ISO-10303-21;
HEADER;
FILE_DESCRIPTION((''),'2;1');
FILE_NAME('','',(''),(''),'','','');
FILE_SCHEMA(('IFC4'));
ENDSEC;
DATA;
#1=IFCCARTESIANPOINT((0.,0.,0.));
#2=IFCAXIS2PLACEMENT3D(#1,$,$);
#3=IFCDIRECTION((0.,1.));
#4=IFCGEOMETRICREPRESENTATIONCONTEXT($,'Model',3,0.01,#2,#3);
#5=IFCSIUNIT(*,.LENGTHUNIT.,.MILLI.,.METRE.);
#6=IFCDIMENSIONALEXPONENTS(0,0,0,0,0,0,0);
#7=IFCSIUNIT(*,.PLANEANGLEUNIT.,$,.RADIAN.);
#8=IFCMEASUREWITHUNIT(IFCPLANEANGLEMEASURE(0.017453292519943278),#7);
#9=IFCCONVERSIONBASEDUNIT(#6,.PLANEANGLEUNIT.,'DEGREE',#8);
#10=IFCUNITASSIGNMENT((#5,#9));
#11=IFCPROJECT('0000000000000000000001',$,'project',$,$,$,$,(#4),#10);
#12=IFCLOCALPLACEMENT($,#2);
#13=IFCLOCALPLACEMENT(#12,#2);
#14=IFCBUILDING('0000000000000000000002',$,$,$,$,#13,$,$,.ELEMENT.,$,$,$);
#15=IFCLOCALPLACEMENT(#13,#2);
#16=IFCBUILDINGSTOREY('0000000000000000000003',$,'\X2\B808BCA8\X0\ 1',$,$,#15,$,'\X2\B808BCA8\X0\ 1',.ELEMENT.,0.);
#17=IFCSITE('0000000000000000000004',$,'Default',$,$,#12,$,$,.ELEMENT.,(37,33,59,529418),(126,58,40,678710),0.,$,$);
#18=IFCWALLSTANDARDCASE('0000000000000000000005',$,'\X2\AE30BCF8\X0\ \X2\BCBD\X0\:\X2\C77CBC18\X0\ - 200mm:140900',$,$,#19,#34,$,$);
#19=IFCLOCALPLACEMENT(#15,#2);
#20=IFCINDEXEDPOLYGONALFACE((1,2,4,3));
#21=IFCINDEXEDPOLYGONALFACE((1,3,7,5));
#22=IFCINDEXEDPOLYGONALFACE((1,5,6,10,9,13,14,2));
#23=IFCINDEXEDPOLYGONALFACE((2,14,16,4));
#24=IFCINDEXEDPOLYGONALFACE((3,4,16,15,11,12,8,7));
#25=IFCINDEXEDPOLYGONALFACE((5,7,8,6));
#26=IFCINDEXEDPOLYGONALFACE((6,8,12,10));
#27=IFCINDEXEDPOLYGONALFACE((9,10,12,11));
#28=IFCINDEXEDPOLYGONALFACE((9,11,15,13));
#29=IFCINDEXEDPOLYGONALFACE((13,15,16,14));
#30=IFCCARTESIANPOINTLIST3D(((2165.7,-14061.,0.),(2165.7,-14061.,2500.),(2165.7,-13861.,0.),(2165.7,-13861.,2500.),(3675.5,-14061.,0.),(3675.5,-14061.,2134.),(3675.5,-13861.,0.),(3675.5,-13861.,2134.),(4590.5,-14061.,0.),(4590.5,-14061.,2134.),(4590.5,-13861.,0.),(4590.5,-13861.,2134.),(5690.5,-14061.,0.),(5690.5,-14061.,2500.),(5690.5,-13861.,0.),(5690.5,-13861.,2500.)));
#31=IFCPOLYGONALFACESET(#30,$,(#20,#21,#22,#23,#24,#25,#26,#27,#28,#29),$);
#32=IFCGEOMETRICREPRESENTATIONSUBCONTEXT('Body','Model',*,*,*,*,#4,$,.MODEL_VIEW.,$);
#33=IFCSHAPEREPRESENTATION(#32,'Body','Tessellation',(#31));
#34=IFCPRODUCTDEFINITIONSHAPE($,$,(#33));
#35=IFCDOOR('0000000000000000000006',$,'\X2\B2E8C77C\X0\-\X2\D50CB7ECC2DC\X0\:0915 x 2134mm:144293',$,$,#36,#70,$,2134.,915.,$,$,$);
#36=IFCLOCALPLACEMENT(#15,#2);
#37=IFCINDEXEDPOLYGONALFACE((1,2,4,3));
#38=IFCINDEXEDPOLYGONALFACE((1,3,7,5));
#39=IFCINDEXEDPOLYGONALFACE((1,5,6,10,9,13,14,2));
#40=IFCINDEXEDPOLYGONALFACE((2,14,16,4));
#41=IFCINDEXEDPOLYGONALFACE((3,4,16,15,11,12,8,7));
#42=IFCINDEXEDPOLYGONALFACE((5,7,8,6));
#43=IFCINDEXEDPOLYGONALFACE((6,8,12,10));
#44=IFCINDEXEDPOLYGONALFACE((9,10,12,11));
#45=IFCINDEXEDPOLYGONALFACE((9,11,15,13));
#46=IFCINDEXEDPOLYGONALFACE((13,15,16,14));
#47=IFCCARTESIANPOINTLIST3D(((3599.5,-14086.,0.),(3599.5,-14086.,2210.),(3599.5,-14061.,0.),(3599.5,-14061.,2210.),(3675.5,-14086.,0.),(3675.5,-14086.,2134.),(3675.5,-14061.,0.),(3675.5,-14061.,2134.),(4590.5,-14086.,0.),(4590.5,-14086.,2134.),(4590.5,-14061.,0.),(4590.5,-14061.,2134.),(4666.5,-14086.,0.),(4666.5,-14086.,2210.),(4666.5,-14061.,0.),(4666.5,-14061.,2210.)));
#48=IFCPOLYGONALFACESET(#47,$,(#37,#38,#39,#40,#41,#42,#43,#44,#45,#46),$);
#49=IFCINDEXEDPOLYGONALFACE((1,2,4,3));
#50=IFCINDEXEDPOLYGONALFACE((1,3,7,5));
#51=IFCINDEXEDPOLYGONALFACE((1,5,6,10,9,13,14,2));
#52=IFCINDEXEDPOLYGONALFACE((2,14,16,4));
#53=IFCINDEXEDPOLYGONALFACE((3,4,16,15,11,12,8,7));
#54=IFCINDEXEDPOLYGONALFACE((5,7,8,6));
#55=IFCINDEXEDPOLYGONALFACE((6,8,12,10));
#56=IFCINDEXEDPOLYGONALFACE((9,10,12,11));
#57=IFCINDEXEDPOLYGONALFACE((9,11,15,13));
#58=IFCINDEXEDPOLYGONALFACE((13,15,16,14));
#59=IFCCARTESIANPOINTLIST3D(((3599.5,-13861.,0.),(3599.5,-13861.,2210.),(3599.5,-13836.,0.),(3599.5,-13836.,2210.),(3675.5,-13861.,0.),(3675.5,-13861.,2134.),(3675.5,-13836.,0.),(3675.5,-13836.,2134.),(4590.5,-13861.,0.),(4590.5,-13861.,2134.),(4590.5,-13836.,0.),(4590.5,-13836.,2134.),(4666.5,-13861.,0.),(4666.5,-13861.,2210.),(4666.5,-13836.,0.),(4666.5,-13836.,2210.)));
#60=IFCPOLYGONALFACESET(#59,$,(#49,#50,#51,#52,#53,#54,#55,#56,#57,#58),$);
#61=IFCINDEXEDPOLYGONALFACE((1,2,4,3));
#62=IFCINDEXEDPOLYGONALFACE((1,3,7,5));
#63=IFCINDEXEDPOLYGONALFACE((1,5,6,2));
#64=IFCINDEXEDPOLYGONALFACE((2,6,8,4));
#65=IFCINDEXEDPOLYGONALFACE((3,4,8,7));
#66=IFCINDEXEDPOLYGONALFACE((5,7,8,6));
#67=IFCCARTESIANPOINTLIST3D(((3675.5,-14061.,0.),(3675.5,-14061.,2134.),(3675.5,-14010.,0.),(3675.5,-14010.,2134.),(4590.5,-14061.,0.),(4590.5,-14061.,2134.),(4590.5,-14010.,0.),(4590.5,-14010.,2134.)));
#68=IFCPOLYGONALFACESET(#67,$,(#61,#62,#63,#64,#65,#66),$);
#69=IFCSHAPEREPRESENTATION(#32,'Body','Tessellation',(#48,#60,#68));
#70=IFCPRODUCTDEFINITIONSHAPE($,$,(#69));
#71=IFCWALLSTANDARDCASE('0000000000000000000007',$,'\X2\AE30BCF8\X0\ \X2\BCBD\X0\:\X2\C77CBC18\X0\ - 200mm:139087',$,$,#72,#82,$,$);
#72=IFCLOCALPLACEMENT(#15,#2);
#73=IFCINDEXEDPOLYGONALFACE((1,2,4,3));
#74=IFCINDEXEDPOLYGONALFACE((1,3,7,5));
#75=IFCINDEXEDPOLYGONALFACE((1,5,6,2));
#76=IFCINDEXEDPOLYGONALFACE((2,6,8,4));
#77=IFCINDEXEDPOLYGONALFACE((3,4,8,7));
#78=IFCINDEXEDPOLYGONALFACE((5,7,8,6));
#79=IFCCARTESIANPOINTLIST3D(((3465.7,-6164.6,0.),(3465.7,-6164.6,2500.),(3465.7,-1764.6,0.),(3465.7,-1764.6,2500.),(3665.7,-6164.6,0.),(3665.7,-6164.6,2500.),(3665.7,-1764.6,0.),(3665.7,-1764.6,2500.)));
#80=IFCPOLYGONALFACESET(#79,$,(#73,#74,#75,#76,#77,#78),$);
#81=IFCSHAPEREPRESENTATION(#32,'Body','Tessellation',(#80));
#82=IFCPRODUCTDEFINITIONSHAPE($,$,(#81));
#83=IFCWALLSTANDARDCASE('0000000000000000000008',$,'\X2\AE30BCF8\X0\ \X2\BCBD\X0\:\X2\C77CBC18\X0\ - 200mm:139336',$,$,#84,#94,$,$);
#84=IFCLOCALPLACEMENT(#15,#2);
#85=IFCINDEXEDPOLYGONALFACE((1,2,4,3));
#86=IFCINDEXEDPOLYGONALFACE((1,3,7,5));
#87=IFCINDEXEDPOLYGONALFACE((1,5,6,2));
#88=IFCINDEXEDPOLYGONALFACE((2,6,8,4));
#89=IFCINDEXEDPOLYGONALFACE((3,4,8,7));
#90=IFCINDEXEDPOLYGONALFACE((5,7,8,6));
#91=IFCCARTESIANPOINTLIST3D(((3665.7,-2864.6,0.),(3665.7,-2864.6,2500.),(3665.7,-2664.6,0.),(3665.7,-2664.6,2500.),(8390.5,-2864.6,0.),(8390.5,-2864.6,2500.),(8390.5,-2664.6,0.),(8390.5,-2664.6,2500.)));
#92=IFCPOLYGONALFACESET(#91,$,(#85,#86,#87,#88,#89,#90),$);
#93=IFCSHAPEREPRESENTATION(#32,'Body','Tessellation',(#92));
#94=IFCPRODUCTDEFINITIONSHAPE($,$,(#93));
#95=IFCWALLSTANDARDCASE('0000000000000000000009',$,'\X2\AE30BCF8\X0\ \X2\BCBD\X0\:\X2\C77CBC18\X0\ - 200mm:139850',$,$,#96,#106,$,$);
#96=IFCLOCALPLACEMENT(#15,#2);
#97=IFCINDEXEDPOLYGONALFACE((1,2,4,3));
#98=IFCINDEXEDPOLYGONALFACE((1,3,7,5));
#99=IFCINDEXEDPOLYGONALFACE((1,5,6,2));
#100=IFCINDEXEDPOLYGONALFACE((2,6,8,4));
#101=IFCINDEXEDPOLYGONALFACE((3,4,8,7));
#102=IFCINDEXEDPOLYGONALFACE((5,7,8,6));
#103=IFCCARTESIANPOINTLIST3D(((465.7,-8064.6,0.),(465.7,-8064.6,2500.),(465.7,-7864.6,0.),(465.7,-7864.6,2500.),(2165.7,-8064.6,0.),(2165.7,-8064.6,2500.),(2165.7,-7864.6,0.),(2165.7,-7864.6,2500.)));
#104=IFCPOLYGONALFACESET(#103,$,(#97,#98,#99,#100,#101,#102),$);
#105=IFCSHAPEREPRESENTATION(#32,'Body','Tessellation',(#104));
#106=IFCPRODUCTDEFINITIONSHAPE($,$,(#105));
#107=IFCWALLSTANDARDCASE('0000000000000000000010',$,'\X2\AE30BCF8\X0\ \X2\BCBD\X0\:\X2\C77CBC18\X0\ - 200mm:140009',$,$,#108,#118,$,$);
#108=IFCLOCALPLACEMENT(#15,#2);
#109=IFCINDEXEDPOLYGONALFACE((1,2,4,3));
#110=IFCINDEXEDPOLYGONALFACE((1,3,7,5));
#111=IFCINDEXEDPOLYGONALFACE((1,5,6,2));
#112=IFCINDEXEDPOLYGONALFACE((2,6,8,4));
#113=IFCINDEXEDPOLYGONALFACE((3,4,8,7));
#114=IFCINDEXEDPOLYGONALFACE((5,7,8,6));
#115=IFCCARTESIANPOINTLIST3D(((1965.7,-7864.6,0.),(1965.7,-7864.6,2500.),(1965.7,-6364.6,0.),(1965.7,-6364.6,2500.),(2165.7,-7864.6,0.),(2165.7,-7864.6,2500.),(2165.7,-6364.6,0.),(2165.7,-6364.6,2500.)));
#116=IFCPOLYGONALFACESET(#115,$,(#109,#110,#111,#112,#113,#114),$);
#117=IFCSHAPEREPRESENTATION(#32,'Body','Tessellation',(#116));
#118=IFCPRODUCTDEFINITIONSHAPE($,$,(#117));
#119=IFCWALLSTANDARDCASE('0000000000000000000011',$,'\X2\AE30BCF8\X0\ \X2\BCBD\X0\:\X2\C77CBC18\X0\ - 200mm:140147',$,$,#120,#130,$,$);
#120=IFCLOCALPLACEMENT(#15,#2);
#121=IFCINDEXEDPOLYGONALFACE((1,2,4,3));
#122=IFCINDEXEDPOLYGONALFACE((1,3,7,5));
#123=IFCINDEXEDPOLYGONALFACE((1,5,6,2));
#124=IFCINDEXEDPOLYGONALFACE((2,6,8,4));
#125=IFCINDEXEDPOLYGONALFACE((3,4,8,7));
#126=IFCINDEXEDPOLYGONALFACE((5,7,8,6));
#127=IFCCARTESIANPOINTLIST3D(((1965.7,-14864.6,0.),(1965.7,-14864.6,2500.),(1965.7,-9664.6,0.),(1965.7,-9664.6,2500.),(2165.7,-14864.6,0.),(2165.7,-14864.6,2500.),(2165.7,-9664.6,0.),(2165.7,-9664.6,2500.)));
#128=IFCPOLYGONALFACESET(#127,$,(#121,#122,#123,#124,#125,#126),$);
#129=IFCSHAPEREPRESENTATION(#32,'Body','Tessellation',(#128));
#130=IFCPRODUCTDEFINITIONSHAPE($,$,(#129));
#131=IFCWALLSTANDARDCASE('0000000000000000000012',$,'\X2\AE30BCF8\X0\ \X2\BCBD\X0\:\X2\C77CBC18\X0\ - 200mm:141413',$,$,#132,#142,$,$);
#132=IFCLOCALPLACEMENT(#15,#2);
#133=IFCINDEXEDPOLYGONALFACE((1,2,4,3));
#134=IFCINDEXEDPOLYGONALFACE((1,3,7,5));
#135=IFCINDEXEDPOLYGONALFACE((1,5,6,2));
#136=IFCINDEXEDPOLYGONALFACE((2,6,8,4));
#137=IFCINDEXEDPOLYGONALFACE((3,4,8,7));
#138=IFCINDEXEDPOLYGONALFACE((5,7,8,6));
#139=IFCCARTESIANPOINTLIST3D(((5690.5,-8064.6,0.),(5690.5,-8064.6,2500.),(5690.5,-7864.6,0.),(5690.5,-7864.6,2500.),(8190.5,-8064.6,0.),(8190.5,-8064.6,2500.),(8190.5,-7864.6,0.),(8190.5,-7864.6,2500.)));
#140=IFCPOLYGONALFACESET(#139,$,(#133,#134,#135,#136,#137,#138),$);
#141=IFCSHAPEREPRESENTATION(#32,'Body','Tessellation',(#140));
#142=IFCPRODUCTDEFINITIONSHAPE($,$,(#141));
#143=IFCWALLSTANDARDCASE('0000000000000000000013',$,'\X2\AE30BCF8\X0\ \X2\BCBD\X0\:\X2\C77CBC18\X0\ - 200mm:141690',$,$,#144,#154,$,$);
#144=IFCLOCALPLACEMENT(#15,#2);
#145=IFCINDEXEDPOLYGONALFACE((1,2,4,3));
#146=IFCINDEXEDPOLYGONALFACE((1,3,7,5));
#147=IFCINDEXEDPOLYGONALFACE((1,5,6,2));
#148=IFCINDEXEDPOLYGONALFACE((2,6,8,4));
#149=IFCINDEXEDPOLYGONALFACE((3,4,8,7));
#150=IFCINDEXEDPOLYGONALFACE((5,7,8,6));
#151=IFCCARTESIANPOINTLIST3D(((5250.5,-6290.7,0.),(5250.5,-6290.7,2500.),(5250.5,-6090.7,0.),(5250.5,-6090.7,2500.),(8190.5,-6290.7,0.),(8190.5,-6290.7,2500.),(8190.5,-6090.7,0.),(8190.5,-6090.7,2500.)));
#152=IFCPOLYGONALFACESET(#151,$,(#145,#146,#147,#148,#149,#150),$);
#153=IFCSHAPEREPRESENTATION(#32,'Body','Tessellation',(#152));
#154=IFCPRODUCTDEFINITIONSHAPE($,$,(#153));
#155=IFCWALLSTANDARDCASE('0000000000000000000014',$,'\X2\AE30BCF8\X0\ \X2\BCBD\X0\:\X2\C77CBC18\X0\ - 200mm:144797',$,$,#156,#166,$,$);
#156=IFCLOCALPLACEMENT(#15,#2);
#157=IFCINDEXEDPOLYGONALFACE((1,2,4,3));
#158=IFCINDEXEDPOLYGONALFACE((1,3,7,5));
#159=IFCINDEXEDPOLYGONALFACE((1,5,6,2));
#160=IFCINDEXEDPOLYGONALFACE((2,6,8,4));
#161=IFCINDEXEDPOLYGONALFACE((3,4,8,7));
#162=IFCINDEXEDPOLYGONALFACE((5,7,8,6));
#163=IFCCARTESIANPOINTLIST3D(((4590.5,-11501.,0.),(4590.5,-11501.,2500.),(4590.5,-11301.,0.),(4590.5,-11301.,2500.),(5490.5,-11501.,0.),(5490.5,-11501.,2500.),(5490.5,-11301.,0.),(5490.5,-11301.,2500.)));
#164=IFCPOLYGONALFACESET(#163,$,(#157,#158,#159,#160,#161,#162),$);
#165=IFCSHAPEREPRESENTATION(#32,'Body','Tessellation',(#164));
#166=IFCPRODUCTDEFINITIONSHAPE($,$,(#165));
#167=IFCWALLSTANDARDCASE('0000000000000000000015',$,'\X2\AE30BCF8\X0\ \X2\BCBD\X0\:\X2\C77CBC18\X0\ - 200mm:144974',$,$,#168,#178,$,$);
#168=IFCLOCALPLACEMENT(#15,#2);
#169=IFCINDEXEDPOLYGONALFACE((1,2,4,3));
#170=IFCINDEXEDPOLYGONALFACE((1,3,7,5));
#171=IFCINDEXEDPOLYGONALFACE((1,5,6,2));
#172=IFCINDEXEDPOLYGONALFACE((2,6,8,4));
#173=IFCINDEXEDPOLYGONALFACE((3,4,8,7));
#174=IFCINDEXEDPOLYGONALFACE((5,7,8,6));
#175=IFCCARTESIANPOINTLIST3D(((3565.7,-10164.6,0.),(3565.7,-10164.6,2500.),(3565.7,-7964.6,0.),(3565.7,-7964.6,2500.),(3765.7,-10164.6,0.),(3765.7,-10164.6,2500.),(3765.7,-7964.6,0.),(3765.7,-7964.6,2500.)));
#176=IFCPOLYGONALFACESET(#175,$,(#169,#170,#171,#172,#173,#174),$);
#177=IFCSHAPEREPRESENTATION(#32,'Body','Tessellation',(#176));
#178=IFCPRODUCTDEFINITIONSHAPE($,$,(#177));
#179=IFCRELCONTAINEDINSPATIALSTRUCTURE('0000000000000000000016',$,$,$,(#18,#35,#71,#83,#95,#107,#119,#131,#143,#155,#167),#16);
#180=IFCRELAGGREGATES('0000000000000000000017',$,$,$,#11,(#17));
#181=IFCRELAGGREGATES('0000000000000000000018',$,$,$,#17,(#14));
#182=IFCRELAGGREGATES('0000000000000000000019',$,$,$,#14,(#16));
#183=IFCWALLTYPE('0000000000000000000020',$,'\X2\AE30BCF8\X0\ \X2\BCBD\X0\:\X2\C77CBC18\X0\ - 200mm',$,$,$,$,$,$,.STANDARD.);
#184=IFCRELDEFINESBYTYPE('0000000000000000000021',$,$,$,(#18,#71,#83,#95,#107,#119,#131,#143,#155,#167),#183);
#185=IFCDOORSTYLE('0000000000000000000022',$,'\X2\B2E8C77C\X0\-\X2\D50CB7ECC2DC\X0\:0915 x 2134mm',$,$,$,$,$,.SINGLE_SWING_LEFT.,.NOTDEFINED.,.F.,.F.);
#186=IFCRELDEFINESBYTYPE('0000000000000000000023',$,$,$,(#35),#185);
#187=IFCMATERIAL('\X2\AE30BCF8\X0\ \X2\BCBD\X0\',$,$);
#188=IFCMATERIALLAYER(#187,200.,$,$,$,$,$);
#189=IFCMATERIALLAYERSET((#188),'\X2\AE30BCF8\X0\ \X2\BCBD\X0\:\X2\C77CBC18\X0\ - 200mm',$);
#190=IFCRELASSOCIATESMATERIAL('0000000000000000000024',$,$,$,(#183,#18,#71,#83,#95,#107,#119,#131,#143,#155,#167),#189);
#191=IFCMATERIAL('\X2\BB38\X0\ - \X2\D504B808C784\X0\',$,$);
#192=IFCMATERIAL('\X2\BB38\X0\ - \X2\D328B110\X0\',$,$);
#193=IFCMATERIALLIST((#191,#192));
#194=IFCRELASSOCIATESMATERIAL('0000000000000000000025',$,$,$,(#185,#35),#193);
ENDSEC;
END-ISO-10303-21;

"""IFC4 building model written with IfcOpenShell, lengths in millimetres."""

from ifc_helpers import new_model, entity, si_unit, converted_unit, direction, frame, frame_2d, origin, place, context, subcontext, project, spatial, polyline, rectangle, outline, extrude, source, transform, mapped, material, material_list, layer, layer_set, layer_usage, type_object, type_shapes, element, fill, save


model = new_model("IFC4")

# Units and contexts
model_context = context("Model", 3, precision=0.01, world=origin(), true_north=direction((0.0, 1.0)))
body_context = subcontext(model_context, "Body", "Model", "MODEL_VIEW")
ifc_project = project(units=[si_unit("LENGTHUNIT", "METRE", prefix="MILLI"), converted_unit("PLANEANGLEUNIT", "DEGREE", entity("IfcPlaneAngleMeasure", 0.017453292519943278), si_unit("PLANEANGLEUNIT", "RADIAN"), dimensions=[0, 0, 0, 0, 0, 0, 0])], contexts=[model_context])

# Site, building, storey
site_placement = place(None, origin())
site = spatial("IfcSite", under=ifc_project, at=site_placement, Name="Default", CompositionType="ELEMENT", RefLatitude=(37, 33, 59, 529418), RefLongitude=(126, 58, 40, 678710), RefElevation=0.0)
building_placement = place(site_placement, origin())
building = spatial("IfcBuilding", under=site, at=building_placement, CompositionType="ELEMENT")
storey_placement = place(building_placement, origin())
storey = spatial("IfcBuildingStorey", under=building, at=storey_placement, Name="레벨 1", LongName="레벨 1", CompositionType="ELEMENT", Elevation=0.0)

# Shared definitions
ifc_material_1 = material(Name="기본 벽")
ifc_layer = layer(ifc_material_1, 200.0)
ifc_layer_set = layer_set([ifc_layer], Name="기본 벽:일반 - 200mm")
wall_type = type_object("IfcWallType", Name="기본 벽:일반 - 200mm", PredefinedType="STANDARD", material=ifc_layer_set)

# Shared definitions
ifc_material_2 = material(Name="문 - 프레임")
ifc_material_3 = material(Name="문 - 패널")
ifc_material_list_1 = material_list([ifc_material_2, ifc_material_3])

# Wall, opening, door
ifc_layer_usage_1 = layer_usage(ifc_layer_set, "AXIS2", "NEGATIVE", 100.0)
wall_1_placement = place(storey_placement, frame((2165.7, -13961.0, 0.0)))
wall_1 = element("IfcWallStandardCase", 1, at=wall_1_placement, inside=storey, type_object=wall_type, material=ifc_layer_usage_1, Name="기본 벽:일반 - 200mm:140900", context=body_context, shape_type="SweptSolid", body=[
    extrude(rectangle(XDim=3524.8, YDim=200.0, at=frame_2d((1762.4, 0.0), x_axis=(1.0, 0.0))), origin(), (0.0, 0.0, 1.0), 2500.0),
])
opening_1_placement = place(wall_1_placement, frame((2424.8, 100.0, 0.0)))
opening_1 = element("IfcOpeningElement", 2, at=opening_1_placement, cuts=wall_1, ObjectType="Opening", context=body_context, shape_type="SweptSolid", body=[
    extrude(rectangle(XDim=915.0, YDim=2134.0, at=frame_2d((1067.0, 457.5), x_axis=(0.0, -1.0))), frame((0.0, 0.0, 0.0), z_axis=(0.0, -1.0, 0.0), x_axis=(0.0, 0.0, 1.0)), (0.0, 0.0, 1.0), 200.0),
])
door_style_1 = type_object("IfcDoorStyle", Name="단일-플러시:0915 x 2134mm", ConstructionType="NOTDEFINED", OperationType="SINGLE_SWING_LEFT", ParameterTakesPrecedence=False, Sizeable=False, material=ifc_material_list_1)
shared_shape_1 = source(origin(), body_context, "Body", "SweptSolid", [
    extrude(outline(polyline([(-533.5, -1124.0), (533.5, -1124.0), (533.5, 1086.0), (457.5, 1086.0), (457.5, -1048.0), (-457.5, -1048.0), (-457.5, 1086.0), (-533.5, 1086.0), (-533.5, -1124.0)])), frame((457.5, 225.0, 1086.0), z_axis=(0.0, -1.0, 0.0), x_axis=(-1.0, 0.0, 0.0)), (0.0, 0.0, 1.0), 25.0),
    extrude(outline(polyline([(-1124.0, -533.5), (1086.0, -533.5), (1086.0, -457.5), (-1048.0, -457.5), (-1048.0, 457.5), (1086.0, 457.5), (1086.0, 533.5), (-1124.0, 533.5), (-1124.0, -533.5)])), frame((457.5, 0.0, 1086.0), z_axis=(0.0, -1.0, 0.0), x_axis=(0.0, 0.0, -1.0)), (0.0, 0.0, 1.0), 25.0),
    extrude(rectangle(XDim=915.0, YDim=51.0, at=frame_2d((0.0, 0.0), x_axis=(1.0, 0.0))), frame((457.5, 174.5, 0.0)), (0.0, 0.0, 1.0), 2134.0),
])
type_shapes(door_style_1, [shared_shape_1])
door_1_placement = place(opening_1_placement, frame((0.0, 0.0, 0.0), z_axis=(0.0, 0.0, 1.0), x_axis=(-1.0, 0.0, 0.0)))
door_1 = element("IfcDoor", 3, at=door_1_placement, inside=storey, type_object=door_style_1, material=ifc_material_list_1, Name="단일-플러시:0915 x 2134mm:144293", OverallHeight=2134.0, OverallWidth=915.0, context=body_context, shape_type="MappedRepresentation", body=[
    mapped(shared_shape_1, transform((0.0, 0.0, 0.0), scale=1.0)),
])
fill(opening_1, door_1)

# Walls
ifc_layer_usage_2 = layer_usage(ifc_layer_set, "AXIS2", "NEGATIVE", 100.0)
wall_2_placement = place(storey_placement, frame((3565.7, -1764.6, 0.0), z_axis=(0.0, 0.0, 1.0), x_axis=(0.0, -1.0, 0.0)))
element("IfcWallStandardCase", 4, at=wall_2_placement, inside=storey, type_object=wall_type, material=ifc_layer_usage_2, Name="기본 벽:일반 - 200mm:139087", context=body_context, shape_type="SweptSolid", body=[
    extrude(rectangle(XDim=4400.0, YDim=200.0, at=frame_2d((2200.0, 0.0), x_axis=(-1.0, 0.0))), origin(), (0.0, 0.0, 1.0), 2500.0),
])
ifc_layer_usage_3 = layer_usage(ifc_layer_set, "AXIS2", "NEGATIVE", 100.0)
wall_3_placement = place(storey_placement, frame((3665.7, -2764.6, 0.0)))
element("IfcWallStandardCase", 5, at=wall_3_placement, inside=storey, type_object=wall_type, material=ifc_layer_usage_3, Name="기본 벽:일반 - 200mm:139336", context=body_context, shape_type="SweptSolid", body=[
    extrude(rectangle(XDim=4724.8, YDim=200.0, at=frame_2d((2362.4, 0.0), x_axis=(-1.0, 0.0))), origin(), (0.0, 0.0, 1.0), 2500.0),
])
ifc_layer_usage_4 = layer_usage(ifc_layer_set, "AXIS2", "NEGATIVE", 100.0)
wall_4_placement = place(storey_placement, frame((465.7, -7964.6, 0.0)))
element("IfcWallStandardCase", 6, at=wall_4_placement, inside=storey, type_object=wall_type, material=ifc_layer_usage_4, Name="기본 벽:일반 - 200mm:139850", context=body_context, shape_type="SweptSolid", body=[
    extrude(rectangle(XDim=1700.0, YDim=200.0, at=frame_2d((850.0, 0.0), x_axis=(-1.0, 0.0))), origin(), (0.0, 0.0, 1.0), 2500.0),
])
ifc_layer_usage_5 = layer_usage(ifc_layer_set, "AXIS2", "NEGATIVE", 100.0)
wall_5_placement = place(storey_placement, frame((2065.7, -6364.6, 0.0), z_axis=(0.0, 0.0, 1.0), x_axis=(0.0, -1.0, 0.0)))
element("IfcWallStandardCase", 7, at=wall_5_placement, inside=storey, type_object=wall_type, material=ifc_layer_usage_5, Name="기본 벽:일반 - 200mm:140009", context=body_context, shape_type="SweptSolid", body=[
    extrude(rectangle(XDim=1500.0, YDim=200.0, at=frame_2d((750.0, 0.0), x_axis=(-1.0, 0.0))), origin(), (0.0, 0.0, 1.0), 2500.0),
])
ifc_layer_usage_6 = layer_usage(ifc_layer_set, "AXIS2", "NEGATIVE", 100.0)
wall_6_placement = place(storey_placement, frame((2065.7, -9664.6, 0.0), z_axis=(0.0, 0.0, 1.0), x_axis=(0.0, -1.0, 0.0)))
element("IfcWallStandardCase", 8, at=wall_6_placement, inside=storey, type_object=wall_type, material=ifc_layer_usage_6, Name="기본 벽:일반 - 200mm:140147", context=body_context, shape_type="SweptSolid", body=[
    extrude(rectangle(XDim=5200.0, YDim=200.0, at=frame_2d((2600.0, 0.0), x_axis=(-1.0, 0.0))), origin(), (0.0, 0.0, 1.0), 2500.0),
])
ifc_layer_usage_7 = layer_usage(ifc_layer_set, "AXIS2", "NEGATIVE", 100.0)
wall_7_placement = place(storey_placement, frame((8190.5, -7964.6, 0.0), z_axis=(0.0, 0.0, 1.0), x_axis=(-1.0, 0.0, 0.0)))
element("IfcWallStandardCase", 9, at=wall_7_placement, inside=storey, type_object=wall_type, material=ifc_layer_usage_7, Name="기본 벽:일반 - 200mm:141413", context=body_context, shape_type="SweptSolid", body=[
    extrude(rectangle(XDim=2500.0, YDim=200.0, at=frame_2d((1250.0, 0.0), x_axis=(-1.0, 0.0))), origin(), (0.0, 0.0, 1.0), 2500.0),
])
ifc_layer_usage_8 = layer_usage(ifc_layer_set, "AXIS2", "NEGATIVE", 100.0)
wall_8_placement = place(storey_placement, frame((5250.5, -6190.7, 0.0)))
element("IfcWallStandardCase", 10, at=wall_8_placement, inside=storey, type_object=wall_type, material=ifc_layer_usage_8, Name="기본 벽:일반 - 200mm:141690", context=body_context, shape_type="SweptSolid", body=[
    extrude(rectangle(XDim=2940.0, YDim=200.0, at=frame_2d((1470.0, 0.0), x_axis=(-1.0, 0.0))), origin(), (0.0, 0.0, 1.0), 2500.0),
])
ifc_layer_usage_9 = layer_usage(ifc_layer_set, "AXIS2", "NEGATIVE", 100.0)
wall_9_placement = place(storey_placement, frame((5490.5, -11401.0, 0.0), z_axis=(0.0, 0.0, 1.0), x_axis=(-1.0, 0.0, 0.0)))
element("IfcWallStandardCase", 11, at=wall_9_placement, inside=storey, type_object=wall_type, material=ifc_layer_usage_9, Name="기본 벽:일반 - 200mm:144797", context=body_context, shape_type="SweptSolid", body=[
    extrude(rectangle(XDim=900.0, YDim=200.0, at=frame_2d((450.0, 0.0), x_axis=(-1.0, 0.0))), origin(), (0.0, 0.0, 1.0), 2500.0),
])
ifc_layer_usage_10 = layer_usage(ifc_layer_set, "AXIS2", "NEGATIVE", 100.0)
wall_10_placement = place(storey_placement, frame((3665.7, -7964.6, 0.0), z_axis=(0.0, 0.0, 1.0), x_axis=(0.0, -1.0, 0.0)))
element("IfcWallStandardCase", 12, at=wall_10_placement, inside=storey, type_object=wall_type, material=ifc_layer_usage_10, Name="기본 벽:일반 - 200mm:144974", context=body_context, shape_type="SweptSolid", body=[
    extrude(rectangle(XDim=2200.0, YDim=200.0, at=frame_2d((1100.0, 0.0), x_axis=(-1.0, 0.0))), origin(), (0.0, 0.0, 1.0), 2500.0),
])

save(model, "model.ifc")
